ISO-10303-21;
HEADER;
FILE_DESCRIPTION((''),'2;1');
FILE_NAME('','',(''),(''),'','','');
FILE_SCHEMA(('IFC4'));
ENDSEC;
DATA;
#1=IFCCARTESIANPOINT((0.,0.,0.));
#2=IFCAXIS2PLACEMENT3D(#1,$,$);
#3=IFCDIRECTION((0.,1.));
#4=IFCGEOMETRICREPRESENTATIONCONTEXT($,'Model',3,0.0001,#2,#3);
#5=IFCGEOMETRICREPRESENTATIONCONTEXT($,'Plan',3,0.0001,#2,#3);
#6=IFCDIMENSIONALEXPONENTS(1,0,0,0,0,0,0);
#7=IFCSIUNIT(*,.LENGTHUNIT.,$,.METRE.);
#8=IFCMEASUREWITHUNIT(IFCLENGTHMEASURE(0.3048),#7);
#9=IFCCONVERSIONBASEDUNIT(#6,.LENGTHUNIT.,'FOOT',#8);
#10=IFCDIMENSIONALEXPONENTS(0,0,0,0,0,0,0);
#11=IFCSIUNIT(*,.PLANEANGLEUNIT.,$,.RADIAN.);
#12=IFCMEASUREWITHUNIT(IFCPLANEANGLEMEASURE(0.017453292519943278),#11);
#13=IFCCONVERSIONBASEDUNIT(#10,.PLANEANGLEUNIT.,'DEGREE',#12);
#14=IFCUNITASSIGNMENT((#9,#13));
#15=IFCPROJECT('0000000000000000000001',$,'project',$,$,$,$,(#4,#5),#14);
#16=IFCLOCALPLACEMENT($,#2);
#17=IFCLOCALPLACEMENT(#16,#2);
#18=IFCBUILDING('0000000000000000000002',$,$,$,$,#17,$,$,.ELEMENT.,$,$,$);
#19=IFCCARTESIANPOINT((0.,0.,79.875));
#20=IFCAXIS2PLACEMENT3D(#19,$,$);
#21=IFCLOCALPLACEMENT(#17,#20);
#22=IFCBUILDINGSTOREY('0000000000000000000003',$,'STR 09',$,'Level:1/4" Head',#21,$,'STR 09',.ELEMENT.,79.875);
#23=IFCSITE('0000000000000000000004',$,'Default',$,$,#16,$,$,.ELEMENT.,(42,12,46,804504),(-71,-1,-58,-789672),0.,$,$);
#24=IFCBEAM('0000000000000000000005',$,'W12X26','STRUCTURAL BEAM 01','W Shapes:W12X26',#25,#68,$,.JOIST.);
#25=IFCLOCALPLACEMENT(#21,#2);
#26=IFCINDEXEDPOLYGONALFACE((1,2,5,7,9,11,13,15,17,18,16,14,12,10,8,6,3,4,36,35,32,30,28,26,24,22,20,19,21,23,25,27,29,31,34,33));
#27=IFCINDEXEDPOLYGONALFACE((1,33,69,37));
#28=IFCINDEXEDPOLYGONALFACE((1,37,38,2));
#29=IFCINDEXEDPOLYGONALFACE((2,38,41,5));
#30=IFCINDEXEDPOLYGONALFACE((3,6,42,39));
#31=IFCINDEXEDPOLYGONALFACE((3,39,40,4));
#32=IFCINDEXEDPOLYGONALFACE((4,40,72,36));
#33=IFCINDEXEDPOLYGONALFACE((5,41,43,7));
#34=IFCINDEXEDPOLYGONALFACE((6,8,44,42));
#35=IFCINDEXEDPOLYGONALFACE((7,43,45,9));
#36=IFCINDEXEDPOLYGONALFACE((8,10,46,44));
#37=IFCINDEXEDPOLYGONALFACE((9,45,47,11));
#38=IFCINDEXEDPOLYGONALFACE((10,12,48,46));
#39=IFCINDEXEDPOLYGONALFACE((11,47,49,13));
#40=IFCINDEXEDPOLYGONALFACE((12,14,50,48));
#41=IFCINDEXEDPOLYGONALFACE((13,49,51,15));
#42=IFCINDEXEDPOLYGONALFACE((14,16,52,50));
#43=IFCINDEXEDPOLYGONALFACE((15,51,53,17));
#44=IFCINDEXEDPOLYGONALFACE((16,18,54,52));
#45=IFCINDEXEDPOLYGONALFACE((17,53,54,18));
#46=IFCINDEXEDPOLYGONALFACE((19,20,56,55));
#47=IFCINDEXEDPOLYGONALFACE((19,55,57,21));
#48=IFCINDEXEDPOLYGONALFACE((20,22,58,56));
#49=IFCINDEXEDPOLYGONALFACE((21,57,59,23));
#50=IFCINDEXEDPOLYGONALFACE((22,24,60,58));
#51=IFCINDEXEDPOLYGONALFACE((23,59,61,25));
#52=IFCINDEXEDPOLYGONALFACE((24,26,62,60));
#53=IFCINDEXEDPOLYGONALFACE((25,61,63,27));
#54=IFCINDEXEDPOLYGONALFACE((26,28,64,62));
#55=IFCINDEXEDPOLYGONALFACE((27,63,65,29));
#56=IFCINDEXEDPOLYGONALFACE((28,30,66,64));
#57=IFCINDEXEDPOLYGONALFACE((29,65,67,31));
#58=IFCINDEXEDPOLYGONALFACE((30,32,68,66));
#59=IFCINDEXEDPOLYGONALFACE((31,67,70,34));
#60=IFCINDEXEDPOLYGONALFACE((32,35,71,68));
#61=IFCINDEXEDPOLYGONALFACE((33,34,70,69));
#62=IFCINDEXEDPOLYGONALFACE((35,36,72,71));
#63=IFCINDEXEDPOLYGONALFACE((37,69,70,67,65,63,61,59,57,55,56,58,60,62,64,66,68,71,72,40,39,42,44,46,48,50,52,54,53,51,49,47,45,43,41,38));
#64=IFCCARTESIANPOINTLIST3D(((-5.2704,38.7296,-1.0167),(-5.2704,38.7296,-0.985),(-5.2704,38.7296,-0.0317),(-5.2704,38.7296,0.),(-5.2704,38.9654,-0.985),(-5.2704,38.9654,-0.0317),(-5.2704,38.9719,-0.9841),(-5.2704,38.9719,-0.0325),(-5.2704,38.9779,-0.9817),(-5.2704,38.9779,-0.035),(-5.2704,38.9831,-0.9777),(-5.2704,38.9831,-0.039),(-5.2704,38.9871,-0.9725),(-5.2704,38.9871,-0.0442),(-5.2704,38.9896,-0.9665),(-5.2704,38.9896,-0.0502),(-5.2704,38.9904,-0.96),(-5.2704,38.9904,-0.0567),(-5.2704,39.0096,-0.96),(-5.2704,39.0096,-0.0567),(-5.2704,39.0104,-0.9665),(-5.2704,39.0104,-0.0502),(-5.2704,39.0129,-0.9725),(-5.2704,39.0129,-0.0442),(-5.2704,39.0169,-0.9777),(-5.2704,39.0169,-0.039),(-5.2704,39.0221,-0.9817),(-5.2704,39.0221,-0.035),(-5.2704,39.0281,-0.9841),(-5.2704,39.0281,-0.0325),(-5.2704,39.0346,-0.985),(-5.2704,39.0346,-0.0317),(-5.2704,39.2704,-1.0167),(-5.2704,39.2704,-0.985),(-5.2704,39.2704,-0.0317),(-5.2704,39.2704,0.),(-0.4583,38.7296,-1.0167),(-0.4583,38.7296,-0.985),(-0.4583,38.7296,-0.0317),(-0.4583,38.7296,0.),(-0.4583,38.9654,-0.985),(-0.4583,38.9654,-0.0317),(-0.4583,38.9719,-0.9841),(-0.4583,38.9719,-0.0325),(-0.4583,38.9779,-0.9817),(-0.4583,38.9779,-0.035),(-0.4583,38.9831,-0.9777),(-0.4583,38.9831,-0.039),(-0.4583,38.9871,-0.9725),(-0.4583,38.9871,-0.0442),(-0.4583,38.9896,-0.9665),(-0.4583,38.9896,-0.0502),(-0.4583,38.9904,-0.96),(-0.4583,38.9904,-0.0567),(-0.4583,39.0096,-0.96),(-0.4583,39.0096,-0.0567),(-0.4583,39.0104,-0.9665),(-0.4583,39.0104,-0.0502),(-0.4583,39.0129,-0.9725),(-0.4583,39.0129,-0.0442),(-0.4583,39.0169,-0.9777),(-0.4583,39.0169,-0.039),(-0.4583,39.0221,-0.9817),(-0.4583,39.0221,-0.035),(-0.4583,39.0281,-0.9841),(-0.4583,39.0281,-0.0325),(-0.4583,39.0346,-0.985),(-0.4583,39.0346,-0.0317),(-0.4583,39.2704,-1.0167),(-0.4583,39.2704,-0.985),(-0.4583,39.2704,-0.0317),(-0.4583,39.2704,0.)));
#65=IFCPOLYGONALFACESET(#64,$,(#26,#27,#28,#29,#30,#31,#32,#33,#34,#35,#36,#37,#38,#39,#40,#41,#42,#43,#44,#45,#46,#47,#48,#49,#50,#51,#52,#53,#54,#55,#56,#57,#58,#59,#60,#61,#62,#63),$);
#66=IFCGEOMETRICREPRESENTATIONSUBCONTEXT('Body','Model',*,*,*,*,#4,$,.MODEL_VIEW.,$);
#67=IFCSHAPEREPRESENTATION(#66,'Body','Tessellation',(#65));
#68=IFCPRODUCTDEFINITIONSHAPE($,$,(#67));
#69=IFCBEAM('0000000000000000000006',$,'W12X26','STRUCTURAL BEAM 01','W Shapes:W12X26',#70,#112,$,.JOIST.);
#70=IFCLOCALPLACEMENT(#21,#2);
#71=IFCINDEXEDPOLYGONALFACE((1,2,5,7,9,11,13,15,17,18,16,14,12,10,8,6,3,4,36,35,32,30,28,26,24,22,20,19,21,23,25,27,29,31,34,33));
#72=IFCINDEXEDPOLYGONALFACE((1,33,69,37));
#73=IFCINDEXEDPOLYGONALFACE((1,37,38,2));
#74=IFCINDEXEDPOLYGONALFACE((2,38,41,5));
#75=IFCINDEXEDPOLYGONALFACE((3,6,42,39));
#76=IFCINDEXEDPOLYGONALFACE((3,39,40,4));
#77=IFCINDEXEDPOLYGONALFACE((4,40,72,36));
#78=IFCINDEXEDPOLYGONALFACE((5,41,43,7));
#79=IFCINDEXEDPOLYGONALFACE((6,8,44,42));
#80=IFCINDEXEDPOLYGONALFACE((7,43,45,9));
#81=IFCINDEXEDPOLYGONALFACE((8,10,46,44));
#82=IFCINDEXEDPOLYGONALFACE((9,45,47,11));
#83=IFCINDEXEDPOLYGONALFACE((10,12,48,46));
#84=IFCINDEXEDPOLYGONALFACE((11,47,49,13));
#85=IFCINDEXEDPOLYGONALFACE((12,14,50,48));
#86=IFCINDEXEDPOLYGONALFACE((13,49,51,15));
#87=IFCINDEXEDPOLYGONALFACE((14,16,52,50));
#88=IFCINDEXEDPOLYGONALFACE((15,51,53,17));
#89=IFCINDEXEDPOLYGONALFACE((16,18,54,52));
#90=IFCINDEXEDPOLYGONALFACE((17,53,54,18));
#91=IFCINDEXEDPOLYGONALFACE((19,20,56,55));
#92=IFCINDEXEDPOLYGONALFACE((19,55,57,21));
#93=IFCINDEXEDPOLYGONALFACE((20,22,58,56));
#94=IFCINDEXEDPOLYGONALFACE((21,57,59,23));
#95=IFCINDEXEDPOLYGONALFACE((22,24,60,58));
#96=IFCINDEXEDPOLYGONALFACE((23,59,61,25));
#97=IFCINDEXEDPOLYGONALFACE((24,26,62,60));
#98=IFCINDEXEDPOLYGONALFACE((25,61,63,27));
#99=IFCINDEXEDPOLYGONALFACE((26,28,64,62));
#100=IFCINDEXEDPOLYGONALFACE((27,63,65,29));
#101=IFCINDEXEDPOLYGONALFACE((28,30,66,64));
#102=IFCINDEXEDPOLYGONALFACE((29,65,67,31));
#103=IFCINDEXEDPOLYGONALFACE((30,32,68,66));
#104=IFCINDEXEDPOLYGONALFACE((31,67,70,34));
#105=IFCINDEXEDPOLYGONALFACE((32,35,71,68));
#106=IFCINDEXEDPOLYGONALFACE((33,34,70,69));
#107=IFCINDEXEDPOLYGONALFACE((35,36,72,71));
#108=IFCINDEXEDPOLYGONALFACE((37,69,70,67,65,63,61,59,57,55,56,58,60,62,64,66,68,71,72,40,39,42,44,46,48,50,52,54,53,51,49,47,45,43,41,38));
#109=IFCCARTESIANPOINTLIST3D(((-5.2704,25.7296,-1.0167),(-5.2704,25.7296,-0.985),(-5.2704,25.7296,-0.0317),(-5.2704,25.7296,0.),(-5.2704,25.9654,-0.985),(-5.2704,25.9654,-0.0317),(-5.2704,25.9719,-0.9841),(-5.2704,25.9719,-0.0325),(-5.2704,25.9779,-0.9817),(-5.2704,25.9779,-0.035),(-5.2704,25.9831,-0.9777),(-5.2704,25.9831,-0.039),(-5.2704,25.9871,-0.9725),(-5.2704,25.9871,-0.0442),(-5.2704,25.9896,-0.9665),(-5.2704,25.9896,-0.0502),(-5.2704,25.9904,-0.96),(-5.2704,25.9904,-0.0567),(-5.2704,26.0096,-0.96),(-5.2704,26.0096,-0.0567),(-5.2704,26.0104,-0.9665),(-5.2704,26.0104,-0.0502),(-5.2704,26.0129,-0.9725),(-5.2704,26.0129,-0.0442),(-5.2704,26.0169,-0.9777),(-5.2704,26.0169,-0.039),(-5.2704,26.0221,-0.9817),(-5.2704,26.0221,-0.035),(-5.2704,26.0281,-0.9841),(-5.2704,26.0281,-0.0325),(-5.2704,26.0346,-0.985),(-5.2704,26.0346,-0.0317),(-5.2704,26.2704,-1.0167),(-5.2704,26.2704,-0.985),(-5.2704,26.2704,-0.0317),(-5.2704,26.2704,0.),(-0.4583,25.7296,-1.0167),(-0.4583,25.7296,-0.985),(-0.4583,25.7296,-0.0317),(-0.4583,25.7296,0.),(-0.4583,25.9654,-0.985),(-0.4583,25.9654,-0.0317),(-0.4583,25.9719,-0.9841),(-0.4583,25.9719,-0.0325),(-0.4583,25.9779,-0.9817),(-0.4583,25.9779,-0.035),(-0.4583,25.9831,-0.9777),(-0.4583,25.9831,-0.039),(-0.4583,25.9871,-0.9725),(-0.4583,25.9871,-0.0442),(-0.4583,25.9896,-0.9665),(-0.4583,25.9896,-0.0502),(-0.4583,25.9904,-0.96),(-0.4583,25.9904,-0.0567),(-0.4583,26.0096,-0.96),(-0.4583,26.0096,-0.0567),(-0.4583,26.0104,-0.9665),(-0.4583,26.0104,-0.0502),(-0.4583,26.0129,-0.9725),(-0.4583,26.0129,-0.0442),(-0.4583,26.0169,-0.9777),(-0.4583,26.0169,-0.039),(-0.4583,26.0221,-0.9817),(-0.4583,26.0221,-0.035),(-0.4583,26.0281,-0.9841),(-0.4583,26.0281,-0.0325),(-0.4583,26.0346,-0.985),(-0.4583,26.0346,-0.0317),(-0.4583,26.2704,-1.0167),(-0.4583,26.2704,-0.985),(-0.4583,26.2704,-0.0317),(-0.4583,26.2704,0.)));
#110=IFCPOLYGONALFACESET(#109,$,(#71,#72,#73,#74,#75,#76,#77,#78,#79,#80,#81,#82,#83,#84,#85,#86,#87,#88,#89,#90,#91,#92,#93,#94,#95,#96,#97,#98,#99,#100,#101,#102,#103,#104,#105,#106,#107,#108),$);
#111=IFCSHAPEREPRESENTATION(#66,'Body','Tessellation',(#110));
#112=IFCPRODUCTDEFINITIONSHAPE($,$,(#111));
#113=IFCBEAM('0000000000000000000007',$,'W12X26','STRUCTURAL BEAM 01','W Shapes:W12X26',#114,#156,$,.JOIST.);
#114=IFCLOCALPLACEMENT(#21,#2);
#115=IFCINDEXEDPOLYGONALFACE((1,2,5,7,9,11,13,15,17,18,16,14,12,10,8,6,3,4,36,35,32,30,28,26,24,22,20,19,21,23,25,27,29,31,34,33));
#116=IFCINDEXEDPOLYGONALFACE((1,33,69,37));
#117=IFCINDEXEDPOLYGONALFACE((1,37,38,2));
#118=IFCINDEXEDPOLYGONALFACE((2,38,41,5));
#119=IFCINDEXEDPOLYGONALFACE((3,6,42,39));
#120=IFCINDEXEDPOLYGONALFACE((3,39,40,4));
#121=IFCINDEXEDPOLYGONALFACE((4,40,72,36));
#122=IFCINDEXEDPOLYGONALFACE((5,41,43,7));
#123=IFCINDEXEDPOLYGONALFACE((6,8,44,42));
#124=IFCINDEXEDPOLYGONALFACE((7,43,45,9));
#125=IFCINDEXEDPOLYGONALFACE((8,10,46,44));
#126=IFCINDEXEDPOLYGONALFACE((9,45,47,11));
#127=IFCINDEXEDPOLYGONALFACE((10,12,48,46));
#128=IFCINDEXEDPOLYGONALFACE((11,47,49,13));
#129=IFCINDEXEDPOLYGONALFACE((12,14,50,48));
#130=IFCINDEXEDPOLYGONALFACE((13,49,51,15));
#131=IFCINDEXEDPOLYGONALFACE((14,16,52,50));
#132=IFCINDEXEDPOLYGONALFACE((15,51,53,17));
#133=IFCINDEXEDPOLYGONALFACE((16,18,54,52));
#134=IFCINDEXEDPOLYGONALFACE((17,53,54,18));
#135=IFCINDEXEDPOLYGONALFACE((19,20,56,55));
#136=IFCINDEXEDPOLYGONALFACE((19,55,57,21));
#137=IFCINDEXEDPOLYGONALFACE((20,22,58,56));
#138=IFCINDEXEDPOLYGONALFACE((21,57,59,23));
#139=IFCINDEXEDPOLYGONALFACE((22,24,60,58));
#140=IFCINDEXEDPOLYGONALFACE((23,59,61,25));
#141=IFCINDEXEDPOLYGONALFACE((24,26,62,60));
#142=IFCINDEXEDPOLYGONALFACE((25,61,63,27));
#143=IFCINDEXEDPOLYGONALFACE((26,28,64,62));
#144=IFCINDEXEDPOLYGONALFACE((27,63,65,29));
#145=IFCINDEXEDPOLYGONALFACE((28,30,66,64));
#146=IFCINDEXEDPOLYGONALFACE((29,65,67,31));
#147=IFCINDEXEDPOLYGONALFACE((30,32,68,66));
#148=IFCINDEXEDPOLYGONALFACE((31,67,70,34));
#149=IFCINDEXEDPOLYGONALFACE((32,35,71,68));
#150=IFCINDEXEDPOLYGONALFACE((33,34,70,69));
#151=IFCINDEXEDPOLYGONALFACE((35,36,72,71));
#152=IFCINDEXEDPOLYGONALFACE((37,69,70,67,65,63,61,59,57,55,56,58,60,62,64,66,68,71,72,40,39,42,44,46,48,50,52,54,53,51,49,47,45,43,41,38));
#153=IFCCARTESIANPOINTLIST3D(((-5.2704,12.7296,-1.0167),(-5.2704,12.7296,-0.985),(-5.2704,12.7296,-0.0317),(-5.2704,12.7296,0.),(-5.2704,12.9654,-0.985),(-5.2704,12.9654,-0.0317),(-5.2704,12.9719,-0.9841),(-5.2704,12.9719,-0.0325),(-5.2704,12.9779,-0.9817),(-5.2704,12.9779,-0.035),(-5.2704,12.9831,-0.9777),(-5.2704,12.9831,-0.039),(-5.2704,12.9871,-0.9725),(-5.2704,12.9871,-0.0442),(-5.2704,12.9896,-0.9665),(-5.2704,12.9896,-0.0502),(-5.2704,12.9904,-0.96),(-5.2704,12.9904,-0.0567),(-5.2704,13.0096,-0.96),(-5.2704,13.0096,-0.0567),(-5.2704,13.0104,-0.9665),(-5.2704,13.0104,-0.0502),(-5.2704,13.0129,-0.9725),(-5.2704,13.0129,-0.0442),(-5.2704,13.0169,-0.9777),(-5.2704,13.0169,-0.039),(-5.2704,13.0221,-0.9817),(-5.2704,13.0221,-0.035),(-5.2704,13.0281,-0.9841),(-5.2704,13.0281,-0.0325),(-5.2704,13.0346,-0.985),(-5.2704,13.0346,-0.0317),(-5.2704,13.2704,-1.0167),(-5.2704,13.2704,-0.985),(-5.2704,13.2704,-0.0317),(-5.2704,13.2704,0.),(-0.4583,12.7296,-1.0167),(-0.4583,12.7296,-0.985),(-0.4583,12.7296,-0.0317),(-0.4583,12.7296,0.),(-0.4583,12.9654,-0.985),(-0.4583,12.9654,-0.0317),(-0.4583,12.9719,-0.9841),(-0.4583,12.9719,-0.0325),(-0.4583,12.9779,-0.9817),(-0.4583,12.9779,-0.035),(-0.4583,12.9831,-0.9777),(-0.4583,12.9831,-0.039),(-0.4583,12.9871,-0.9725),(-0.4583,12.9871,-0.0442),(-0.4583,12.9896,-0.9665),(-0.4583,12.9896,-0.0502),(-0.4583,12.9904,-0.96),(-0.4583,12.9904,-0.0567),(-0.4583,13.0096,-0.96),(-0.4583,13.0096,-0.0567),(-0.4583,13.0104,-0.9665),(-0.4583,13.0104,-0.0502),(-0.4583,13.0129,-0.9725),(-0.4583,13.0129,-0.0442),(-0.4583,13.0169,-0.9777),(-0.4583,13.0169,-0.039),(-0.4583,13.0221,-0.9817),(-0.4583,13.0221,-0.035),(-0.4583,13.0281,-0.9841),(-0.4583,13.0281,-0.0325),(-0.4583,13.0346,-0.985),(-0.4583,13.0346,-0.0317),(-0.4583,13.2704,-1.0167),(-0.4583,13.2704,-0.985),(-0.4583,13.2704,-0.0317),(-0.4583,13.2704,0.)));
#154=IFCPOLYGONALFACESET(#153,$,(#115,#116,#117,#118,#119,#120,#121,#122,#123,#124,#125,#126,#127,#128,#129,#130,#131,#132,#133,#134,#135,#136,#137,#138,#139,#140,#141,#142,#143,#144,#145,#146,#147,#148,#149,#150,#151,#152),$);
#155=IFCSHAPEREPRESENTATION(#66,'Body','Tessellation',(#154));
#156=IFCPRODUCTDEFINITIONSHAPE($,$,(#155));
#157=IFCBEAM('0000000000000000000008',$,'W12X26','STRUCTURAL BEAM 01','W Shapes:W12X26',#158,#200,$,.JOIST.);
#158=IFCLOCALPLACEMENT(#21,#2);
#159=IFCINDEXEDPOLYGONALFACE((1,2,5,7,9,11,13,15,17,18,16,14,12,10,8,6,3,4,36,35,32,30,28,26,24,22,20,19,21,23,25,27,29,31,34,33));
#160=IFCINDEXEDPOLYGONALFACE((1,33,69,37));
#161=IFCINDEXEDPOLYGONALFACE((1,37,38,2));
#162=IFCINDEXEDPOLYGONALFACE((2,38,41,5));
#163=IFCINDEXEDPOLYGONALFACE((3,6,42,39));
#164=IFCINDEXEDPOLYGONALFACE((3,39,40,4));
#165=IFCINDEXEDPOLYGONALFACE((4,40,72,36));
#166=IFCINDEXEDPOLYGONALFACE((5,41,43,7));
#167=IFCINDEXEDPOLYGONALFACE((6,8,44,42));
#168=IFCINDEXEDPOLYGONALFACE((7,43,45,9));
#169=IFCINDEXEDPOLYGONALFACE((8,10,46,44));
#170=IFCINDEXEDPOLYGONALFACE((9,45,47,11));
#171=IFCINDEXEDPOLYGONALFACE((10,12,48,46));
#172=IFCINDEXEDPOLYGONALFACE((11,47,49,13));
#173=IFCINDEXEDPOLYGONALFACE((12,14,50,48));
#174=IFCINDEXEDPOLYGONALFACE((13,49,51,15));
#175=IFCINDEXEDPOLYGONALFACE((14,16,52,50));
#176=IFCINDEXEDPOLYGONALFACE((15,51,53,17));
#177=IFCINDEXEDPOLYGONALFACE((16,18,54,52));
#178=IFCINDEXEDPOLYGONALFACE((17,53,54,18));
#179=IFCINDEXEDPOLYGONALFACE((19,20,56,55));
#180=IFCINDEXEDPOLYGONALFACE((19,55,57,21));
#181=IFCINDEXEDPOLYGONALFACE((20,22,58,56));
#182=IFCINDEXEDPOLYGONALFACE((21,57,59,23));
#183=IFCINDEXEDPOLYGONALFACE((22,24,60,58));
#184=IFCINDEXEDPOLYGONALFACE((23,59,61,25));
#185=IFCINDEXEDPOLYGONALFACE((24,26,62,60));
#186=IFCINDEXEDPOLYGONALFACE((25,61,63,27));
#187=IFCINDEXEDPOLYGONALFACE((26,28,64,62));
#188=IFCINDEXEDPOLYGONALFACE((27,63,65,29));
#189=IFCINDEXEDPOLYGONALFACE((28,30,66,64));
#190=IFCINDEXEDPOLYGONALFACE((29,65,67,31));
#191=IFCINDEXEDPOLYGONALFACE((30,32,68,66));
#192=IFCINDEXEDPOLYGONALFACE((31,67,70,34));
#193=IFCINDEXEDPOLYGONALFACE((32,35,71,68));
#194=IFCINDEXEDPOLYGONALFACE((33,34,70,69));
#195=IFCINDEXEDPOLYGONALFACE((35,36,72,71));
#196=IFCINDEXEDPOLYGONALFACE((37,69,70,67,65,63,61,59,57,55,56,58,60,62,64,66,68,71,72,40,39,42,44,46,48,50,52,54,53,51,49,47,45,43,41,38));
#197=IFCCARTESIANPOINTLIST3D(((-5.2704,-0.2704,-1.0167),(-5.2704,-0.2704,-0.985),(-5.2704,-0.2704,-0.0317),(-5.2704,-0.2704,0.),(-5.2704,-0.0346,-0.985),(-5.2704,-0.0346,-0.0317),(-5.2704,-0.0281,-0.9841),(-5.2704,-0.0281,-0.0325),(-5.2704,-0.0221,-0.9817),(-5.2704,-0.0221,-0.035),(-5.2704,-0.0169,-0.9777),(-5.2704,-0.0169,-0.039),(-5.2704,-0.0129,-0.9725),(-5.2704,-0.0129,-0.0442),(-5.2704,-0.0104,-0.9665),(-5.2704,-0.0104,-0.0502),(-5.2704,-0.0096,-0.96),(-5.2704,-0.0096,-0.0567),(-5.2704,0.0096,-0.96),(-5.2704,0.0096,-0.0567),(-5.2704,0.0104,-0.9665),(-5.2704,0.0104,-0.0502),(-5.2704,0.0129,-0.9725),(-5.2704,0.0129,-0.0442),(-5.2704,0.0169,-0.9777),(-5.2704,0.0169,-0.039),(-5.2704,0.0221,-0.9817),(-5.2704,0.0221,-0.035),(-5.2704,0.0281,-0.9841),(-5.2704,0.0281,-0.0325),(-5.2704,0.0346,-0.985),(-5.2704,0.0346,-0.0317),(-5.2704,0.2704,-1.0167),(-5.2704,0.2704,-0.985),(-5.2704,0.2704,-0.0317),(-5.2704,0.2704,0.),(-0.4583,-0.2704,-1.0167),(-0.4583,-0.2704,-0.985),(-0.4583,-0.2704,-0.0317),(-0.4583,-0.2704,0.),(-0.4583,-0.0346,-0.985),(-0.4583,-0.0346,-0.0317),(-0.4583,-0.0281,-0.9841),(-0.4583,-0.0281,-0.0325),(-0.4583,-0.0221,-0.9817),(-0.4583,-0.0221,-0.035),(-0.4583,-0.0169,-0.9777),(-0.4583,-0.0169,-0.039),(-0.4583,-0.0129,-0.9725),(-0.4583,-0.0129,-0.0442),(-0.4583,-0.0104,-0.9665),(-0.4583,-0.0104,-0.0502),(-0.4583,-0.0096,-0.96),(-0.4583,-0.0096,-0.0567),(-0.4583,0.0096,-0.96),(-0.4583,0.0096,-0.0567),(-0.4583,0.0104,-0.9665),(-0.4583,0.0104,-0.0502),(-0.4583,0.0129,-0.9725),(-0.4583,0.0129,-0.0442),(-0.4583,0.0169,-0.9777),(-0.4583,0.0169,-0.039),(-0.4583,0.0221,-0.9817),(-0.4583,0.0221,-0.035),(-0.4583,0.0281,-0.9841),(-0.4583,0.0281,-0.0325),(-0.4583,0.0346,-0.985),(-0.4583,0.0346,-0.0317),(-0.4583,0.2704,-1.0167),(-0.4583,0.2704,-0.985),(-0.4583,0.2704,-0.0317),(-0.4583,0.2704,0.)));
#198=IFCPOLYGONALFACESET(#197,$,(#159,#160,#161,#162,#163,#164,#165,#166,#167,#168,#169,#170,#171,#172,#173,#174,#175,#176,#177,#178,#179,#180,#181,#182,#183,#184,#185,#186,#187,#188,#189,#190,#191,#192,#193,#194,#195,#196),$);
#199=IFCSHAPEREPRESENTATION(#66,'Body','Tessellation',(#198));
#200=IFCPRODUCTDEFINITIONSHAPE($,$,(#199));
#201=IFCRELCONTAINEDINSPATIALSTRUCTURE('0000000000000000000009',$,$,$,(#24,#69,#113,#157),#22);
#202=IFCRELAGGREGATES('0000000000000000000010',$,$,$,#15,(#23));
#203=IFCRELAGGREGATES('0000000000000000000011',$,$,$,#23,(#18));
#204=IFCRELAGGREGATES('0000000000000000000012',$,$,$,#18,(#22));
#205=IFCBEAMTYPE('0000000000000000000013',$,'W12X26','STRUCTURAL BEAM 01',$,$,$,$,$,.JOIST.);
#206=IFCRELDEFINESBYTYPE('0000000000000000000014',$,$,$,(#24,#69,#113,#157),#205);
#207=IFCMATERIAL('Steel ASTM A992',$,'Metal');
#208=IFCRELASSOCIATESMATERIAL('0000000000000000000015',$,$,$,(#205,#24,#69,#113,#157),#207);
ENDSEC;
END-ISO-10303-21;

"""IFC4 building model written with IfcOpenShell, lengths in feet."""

from ifc_helpers import new_model, entity, si_unit, converted_unit, direction, frame, origin, place, context, subcontext, project, spatial, line, arc, indexed_curve, outline, extrude, source, transform, mapped, material, type_object, type_shapes, element, save


model = new_model("IFC4")

# Units and contexts
model_context = context("Model", 3, precision=0.0001, world=origin(), true_north=direction((0.0, 1.0)))
plan_context = context("Plan", 3, precision=0.0001, world=origin(), true_north=direction((0.0, 1.0)))
body_context = subcontext(model_context, "Body", "Model", "MODEL_VIEW")
ifc_project = project(units=[converted_unit("LENGTHUNIT", "FOOT", entity("IfcLengthMeasure", 0.3048), si_unit("LENGTHUNIT", "METRE"), dimensions=[1, 0, 0, 0, 0, 0, 0]), converted_unit("PLANEANGLEUNIT", "DEGREE", entity("IfcPlaneAngleMeasure", 0.017453292519943278), si_unit("PLANEANGLEUNIT", "RADIAN"), dimensions=[0, 0, 0, 0, 0, 0, 0])], contexts=[model_context, plan_context])

# Site, building, storey
site_placement = place(None, origin())
site = spatial("IfcSite", under=ifc_project, at=site_placement, Name="Default", CompositionType="ELEMENT", RefLatitude=(42, 12, 46, 804504), RefLongitude=(-71, -1, -58, -789672), RefElevation=0.0)
building_placement = place(site_placement, origin())
building = spatial("IfcBuilding", under=site, at=building_placement, CompositionType="ELEMENT")
storey_placement = place(building_placement, frame((0.0, 0.0, 79.875)))
storey = spatial("IfcBuildingStorey", under=building, at=storey_placement, Name="STR 09", ObjectType="Level:1/4\" Head", LongName="STR 09", CompositionType="ELEMENT", Elevation=79.875)

# Beams
ifc_material = material(Name="Steel ASTM A992", Category="Metal")
beam_type_1 = type_object("IfcBeamType", Name="W12X26", Description="STRUCTURAL BEAM 01", PredefinedType="JOIST", material=ifc_material)
shared_shape_1 = source(origin(), body_context, "Body", "SweptSolid", [
    extrude(outline(indexed_curve([(0.4767, -0.2704), (0.5083, -0.2704), (0.5083, 0.2704), (0.4767, 0.2704), (0.4767, 0.0346), (0.4693, 0.0169), (0.4517, 0.0096), (-0.4517, 0.0096), (-0.4693, 0.0169), (-0.4767, 0.0346), (-0.4767, 0.2704), (-0.5083, 0.2704), (-0.5083, -0.2704), (-0.4767, -0.2704), (-0.4767, -0.0346), (-0.4693, -0.0169), (-0.4517, -0.0096), (0.4517, -0.0096), (0.4693, -0.0169), (0.4767, -0.0346)], segments=[line(1, 2, 3, 4, 5), arc(5, 6, 7), line(7, 8), arc(8, 9, 10), line(10, 11, 12, 13, 14, 15), arc(15, 16, 17), line(17, 18), arc(18, 19, 20), line(20, 1)], self_intersect=False)), frame((-2.0417, 0.0, 0.0), z_axis=(1.0, 0.0, 0.0), x_axis=(0.0, 0.0, -1.0)), (0.0, 0.0, 1.0), 4.8121),
])
type_shapes(beam_type_1, [shared_shape_1])
for number, where, z_axis, x_axis, name in (
    (1, (-2.5, 39.0, -0.5083), (0.0, 0.0, 1.0), (-1.0, 0.0, 0.0), "W12X26"),
    (2, (-2.5, 26.0, -0.5083), (0.0, 0.0, 1.0), (-1.0, 0.0, 0.0), "W12X26"),
    (3, (-2.5, 13.0, -0.5083), (0.0, 0.0, 1.0), (-1.0, 0.0, 0.0), "W12X26"),
    (4, (-2.5, 0.0, -0.5083), (0.0, 0.0, 1.0), (-1.0, 0.0, 0.0), "W12X26"),
):
    element("IfcBeam", number, at=place(storey_placement, frame(where, z_axis=z_axis, x_axis=x_axis)), inside=storey, type_object=beam_type_1, material=ifc_material, Name=name, Description="STRUCTURAL BEAM 01", ObjectType="W Shapes:W12X26", PredefinedType="JOIST", context=body_context, shape_type="MappedRepresentation", body=[
        mapped(shared_shape_1, transform((0.0, 0.0, 0.0), scale=1.0)),
    ])

save(model, "model.ifc")
